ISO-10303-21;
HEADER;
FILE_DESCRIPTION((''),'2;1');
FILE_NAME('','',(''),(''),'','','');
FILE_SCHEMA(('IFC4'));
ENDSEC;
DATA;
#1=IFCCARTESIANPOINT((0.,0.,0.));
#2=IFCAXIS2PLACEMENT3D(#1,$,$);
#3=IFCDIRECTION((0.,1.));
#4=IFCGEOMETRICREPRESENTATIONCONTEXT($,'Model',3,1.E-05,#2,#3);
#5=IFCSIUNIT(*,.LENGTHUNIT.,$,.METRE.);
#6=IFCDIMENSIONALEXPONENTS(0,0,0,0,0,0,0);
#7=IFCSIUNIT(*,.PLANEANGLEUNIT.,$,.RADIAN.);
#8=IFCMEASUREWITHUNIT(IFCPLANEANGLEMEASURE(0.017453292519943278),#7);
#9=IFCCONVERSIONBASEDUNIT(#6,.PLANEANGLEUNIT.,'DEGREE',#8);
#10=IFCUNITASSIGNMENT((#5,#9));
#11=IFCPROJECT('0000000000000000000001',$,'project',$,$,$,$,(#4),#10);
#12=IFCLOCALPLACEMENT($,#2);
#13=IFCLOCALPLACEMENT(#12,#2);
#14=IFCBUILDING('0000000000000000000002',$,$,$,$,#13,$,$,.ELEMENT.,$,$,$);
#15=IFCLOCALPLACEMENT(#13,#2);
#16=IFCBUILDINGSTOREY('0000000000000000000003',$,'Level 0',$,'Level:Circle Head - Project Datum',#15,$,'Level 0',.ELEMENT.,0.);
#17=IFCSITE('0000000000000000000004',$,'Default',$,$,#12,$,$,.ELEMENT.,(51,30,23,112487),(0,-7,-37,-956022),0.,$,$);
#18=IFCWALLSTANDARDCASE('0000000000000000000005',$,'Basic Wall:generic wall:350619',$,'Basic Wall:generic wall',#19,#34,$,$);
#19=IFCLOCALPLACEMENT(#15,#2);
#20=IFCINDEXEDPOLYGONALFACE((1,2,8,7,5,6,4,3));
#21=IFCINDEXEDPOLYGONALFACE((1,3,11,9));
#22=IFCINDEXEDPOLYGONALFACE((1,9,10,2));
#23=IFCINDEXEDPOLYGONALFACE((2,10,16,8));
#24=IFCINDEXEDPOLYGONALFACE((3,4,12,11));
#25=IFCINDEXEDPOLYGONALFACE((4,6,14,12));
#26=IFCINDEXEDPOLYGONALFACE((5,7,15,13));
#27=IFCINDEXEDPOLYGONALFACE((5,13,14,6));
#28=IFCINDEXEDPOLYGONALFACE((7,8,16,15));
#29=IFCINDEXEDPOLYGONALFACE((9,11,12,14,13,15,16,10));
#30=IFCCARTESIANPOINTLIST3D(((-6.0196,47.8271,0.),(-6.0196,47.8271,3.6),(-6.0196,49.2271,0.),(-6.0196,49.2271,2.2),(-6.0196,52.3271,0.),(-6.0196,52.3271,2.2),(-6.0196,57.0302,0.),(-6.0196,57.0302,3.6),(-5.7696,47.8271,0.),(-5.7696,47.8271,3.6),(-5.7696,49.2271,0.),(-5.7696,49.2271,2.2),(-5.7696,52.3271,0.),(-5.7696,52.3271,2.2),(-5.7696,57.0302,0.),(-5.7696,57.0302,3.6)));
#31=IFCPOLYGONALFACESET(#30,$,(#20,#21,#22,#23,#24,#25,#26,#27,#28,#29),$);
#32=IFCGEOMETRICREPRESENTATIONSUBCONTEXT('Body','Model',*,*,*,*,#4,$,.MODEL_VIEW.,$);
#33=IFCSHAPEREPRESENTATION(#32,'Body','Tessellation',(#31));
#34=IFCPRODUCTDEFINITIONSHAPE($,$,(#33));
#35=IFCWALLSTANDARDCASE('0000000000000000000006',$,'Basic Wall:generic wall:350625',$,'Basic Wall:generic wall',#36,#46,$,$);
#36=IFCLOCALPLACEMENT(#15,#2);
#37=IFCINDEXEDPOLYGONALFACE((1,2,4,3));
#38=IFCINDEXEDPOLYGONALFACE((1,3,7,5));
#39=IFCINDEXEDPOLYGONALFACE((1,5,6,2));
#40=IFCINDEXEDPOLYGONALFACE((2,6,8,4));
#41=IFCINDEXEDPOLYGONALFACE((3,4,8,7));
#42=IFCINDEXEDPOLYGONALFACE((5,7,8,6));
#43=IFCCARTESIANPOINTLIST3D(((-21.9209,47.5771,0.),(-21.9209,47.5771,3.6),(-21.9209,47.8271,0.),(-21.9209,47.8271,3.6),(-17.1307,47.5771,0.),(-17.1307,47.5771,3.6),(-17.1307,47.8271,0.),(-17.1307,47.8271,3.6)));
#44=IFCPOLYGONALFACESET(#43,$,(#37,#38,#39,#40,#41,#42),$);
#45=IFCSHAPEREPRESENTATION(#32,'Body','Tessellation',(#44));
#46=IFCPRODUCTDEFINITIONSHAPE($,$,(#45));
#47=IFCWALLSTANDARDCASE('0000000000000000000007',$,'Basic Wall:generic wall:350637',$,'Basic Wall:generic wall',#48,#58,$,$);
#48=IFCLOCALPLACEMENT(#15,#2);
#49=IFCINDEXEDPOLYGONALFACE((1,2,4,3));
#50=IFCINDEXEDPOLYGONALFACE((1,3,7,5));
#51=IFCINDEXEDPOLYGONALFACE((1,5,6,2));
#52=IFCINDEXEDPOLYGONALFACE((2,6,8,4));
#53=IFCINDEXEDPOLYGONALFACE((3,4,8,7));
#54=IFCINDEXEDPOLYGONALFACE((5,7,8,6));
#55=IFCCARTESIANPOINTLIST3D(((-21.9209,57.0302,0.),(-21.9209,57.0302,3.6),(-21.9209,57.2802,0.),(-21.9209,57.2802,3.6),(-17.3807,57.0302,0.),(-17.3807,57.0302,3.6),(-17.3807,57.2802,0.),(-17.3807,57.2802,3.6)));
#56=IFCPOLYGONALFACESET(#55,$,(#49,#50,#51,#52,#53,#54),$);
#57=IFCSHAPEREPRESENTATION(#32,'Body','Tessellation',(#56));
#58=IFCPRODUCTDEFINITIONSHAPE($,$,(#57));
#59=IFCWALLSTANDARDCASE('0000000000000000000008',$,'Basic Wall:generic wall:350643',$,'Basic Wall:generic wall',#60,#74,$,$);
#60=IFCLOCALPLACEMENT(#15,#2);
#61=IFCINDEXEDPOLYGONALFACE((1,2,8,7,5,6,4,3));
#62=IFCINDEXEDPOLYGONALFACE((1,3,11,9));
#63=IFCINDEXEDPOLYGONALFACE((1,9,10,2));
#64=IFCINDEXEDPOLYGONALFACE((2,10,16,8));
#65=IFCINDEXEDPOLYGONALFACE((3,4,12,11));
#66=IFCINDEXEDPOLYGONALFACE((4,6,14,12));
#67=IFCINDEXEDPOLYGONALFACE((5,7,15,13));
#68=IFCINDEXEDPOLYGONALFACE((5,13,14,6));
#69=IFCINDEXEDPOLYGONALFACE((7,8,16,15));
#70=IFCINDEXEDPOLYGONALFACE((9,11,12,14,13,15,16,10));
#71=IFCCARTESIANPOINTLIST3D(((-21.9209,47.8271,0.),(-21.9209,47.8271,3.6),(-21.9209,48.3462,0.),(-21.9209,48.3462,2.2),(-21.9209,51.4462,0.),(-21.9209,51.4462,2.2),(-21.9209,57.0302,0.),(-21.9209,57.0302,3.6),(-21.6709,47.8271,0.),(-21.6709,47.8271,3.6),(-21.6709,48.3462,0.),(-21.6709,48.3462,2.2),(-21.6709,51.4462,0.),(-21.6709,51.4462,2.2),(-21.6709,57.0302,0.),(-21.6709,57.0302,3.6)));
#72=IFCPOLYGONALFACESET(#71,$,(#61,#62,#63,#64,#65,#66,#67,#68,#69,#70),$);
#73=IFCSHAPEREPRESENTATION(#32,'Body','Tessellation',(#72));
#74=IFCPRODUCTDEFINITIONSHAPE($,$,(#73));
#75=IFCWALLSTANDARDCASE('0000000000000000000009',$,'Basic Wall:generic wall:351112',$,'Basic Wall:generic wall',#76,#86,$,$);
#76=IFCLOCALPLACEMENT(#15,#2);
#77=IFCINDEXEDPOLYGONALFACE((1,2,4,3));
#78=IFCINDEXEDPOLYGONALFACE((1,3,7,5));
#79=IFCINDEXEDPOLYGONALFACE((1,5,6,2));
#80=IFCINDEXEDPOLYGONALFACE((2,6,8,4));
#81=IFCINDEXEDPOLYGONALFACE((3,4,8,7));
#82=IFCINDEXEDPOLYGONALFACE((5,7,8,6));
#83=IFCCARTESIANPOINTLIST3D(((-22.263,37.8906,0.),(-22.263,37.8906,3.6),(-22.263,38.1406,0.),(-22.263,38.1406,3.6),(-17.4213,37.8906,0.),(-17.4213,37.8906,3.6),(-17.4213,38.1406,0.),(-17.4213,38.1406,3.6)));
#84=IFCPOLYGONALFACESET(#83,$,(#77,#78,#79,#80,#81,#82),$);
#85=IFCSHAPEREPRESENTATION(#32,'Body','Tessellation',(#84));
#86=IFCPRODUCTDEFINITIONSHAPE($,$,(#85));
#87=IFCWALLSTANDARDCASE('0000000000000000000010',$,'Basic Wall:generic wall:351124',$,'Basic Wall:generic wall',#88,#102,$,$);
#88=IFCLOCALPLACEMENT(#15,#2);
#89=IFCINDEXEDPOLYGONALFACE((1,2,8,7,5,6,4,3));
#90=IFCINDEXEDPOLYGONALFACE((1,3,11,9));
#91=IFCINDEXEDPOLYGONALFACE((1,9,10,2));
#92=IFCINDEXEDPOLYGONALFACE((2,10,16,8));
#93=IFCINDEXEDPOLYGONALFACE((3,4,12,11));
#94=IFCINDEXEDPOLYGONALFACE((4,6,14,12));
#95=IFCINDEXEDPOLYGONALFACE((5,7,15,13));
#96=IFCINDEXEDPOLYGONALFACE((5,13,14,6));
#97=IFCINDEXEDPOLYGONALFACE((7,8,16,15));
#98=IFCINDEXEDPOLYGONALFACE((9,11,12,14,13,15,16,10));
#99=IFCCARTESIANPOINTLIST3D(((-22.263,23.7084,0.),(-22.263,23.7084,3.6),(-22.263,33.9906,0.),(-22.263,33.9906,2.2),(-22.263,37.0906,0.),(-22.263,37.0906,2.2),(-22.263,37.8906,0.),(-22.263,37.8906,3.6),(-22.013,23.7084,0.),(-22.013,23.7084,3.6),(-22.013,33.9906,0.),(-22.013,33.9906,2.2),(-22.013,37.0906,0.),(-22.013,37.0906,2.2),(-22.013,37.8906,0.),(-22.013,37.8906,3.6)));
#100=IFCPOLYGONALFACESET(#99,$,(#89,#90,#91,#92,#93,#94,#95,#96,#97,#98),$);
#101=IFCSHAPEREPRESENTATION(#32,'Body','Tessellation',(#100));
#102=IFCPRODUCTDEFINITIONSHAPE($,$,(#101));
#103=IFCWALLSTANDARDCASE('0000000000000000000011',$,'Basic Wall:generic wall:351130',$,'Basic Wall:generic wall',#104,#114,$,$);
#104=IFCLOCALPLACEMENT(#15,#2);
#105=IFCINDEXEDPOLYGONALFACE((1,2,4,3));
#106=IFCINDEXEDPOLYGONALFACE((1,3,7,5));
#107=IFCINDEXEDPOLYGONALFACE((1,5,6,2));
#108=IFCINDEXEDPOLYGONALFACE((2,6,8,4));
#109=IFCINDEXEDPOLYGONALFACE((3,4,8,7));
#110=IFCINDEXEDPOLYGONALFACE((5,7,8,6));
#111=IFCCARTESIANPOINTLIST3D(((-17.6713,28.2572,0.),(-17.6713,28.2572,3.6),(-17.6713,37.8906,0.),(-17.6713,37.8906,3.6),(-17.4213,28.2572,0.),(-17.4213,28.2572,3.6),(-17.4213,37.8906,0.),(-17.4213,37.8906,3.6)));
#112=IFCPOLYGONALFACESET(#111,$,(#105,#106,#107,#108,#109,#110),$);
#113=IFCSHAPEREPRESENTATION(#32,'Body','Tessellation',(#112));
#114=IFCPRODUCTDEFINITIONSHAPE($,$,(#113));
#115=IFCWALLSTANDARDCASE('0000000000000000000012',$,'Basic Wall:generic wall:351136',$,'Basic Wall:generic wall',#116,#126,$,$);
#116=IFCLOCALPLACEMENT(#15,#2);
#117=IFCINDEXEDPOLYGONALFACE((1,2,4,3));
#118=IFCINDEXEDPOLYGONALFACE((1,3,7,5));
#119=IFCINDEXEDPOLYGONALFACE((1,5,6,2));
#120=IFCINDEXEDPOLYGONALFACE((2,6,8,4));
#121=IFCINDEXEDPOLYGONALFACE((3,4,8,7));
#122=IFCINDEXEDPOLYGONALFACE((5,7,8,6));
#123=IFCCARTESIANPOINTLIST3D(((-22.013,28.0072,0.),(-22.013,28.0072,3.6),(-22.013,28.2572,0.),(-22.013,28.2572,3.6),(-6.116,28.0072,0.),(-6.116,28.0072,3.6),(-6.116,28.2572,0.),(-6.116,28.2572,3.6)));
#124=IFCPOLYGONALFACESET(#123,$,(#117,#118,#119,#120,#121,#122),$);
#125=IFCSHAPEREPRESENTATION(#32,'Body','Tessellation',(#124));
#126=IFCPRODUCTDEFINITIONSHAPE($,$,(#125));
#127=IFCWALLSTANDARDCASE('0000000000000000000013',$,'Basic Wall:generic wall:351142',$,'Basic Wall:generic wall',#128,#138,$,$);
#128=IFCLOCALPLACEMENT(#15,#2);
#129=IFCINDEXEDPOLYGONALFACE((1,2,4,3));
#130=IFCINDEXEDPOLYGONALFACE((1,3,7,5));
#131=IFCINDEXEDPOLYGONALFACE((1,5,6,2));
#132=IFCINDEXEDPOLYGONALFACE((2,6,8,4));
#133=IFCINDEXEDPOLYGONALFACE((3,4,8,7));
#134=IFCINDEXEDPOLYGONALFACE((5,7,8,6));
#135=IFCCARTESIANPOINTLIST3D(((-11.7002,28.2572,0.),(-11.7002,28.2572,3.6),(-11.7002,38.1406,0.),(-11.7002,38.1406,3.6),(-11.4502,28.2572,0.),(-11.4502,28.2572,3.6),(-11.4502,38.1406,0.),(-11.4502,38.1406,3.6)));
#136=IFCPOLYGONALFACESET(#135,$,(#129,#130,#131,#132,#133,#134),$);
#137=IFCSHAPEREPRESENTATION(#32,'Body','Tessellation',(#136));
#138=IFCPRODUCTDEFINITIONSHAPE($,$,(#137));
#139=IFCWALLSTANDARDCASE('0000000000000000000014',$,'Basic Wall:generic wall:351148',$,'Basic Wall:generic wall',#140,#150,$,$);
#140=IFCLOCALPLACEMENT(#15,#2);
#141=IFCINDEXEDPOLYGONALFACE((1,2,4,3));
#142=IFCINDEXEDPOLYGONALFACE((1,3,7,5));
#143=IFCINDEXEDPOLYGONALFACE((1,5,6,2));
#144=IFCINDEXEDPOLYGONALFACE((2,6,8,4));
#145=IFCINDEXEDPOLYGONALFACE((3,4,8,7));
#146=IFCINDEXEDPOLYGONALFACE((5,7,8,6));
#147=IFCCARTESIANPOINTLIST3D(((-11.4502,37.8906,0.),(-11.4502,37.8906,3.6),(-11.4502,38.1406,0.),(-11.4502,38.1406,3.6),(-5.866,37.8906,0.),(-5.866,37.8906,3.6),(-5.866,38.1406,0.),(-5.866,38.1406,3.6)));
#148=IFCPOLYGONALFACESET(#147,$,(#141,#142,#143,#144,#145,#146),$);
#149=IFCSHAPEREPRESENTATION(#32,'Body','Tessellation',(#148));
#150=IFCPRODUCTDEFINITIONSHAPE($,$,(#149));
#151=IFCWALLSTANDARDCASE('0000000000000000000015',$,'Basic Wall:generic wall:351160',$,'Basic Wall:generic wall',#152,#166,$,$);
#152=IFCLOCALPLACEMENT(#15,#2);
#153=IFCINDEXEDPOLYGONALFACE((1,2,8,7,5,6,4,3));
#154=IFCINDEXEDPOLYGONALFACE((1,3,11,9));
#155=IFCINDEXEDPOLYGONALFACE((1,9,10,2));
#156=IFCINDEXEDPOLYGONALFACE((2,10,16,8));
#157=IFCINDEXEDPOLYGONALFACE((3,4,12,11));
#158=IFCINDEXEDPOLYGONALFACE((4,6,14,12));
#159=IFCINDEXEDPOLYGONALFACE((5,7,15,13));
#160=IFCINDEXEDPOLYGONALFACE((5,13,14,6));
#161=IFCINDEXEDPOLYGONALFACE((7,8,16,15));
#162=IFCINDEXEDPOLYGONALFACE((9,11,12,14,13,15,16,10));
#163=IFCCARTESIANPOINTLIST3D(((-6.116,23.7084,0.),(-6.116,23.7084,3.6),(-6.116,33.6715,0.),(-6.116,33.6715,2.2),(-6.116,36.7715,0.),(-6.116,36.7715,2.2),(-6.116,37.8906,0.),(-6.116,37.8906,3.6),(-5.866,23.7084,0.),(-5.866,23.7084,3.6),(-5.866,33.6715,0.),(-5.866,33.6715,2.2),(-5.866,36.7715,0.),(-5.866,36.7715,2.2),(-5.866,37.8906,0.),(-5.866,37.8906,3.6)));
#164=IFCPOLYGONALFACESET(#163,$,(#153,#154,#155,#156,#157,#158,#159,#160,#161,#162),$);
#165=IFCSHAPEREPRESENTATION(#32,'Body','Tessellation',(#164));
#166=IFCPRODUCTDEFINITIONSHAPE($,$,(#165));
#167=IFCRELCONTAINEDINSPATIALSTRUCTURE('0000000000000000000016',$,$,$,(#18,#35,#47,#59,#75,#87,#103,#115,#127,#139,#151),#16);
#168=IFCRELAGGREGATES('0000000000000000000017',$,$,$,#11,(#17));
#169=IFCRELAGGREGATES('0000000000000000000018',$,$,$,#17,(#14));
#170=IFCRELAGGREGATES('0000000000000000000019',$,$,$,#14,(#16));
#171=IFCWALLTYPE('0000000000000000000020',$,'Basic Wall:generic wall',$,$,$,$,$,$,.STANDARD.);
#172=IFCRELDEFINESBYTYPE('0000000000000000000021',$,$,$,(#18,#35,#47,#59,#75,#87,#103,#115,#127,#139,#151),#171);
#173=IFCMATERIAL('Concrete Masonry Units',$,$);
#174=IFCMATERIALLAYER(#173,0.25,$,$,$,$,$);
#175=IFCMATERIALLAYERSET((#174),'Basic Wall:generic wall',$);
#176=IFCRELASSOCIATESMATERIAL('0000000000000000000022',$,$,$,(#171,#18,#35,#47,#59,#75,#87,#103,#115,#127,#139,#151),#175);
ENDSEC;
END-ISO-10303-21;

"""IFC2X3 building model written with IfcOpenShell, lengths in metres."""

from ifc_helpers import new_model, entity, si_unit, converted_unit, direction, frame, frame_2d, origin, place, context, subcontext, project, spatial, rectangle, extrude, material, layer, layer_set, layer_usage, type_object, element, save


model = new_model("IFC2X3")

# Units and contexts
model_context = context("Model", 3, precision=1e-05, world=origin(), true_north=direction((0.0, 1.0)))
body_context = subcontext(model_context, "Body", "Model", "MODEL_VIEW")
ifc_project = project(units=[si_unit("LENGTHUNIT", "METRE"), converted_unit("PLANEANGLEUNIT", "DEGREE", entity("IfcPlaneAngleMeasure", 0.017453292519943278), si_unit("PLANEANGLEUNIT", "RADIAN"), dimensions=[0, 0, 0, 0, 0, 0, 0])], contexts=[model_context])

# Site, building, storey
site_placement = place(None, origin())
site = spatial("IfcSite", under=ifc_project, at=site_placement, Name="Default", CompositionType="ELEMENT", RefLatitude=(51, 30, 23, 112487), RefLongitude=(0, -7, -37, -956022), RefElevation=0.0)
building_placement = place(site_placement, origin())
building = spatial("IfcBuilding", under=site, at=building_placement, CompositionType="ELEMENT")
storey_placement = place(building_placement, origin())
storey = spatial("IfcBuildingStorey", under=building, at=storey_placement, Name="Level 0", ObjectType="Level:Circle Head - Project Datum", LongName="Level 0", CompositionType="ELEMENT", Elevation=0.0)

# Shared definitions
ifc_material = material(Name="Concrete Masonry Units")
ifc_layer = layer(ifc_material, 0.25)
ifc_layer_set = layer_set([ifc_layer], Name="Basic Wall:generic wall")
wall_type = type_object("IfcWallType", Name="Basic Wall:generic wall", PredefinedType="STANDARD", material=ifc_layer_set)

# Wall, opening
ifc_layer_usage_1 = layer_usage(ifc_layer_set, "AXIS2", "NEGATIVE", 0.125)
wall_1_placement = place(storey_placement, frame((-5.8946, 57.0302, 0.0), z_axis=(0.0, 0.0, 1.0), x_axis=(0.0, -1.0, 0.0)))
wall_1 = element("IfcWallStandardCase", 1, at=wall_1_placement, inside=storey, type_object=wall_type, material=ifc_layer_usage_1, Name="Basic Wall:generic wall:350619", ObjectType="Basic Wall:generic wall", context=body_context, shape_type="SweptSolid", body=[
    extrude(rectangle(XDim=9.2031, YDim=0.25, at=frame_2d((4.6015, 0.0), x_axis=(1.0, 0.0))), origin(), (0.0, 0.0, 1.0), 3.6),
])
opening_1_placement = place(wall_1_placement, frame((7.8031, 0.125, 0.0)))
element("IfcOpeningElement", 2, at=opening_1_placement, cuts=wall_1, ObjectType="Opening", context=body_context, shape_type="SweptSolid", body=[
    extrude(rectangle(XDim=2.2, YDim=3.1, at=frame_2d((1.1, 1.55), x_axis=(1.0, 0.0))), frame((0.0, 0.0, 0.0), z_axis=(0.0, -1.0, 0.0), x_axis=(0.0, 0.0, 1.0)), (0.0, 0.0, 1.0), 0.25),
])

# Walls
ifc_layer_usage_2 = layer_usage(ifc_layer_set, "AXIS2", "NEGATIVE", 0.125)
wall_2_placement = place(storey_placement, frame((-17.1307, 47.7021, 0.0), z_axis=(0.0, 0.0, 1.0), x_axis=(-1.0, 0.0, 0.0)))
element("IfcWallStandardCase", 3, at=wall_2_placement, inside=storey, type_object=wall_type, material=ifc_layer_usage_2, Name="Basic Wall:generic wall:350625", ObjectType="Basic Wall:generic wall", context=body_context, shape_type="SweptSolid", body=[
    extrude(rectangle(XDim=4.7901, YDim=0.25, at=frame_2d((2.3951, 0.0), x_axis=(-1.0, 0.0))), origin(), (0.0, 0.0, 1.0), 3.6),
])
ifc_layer_usage_3 = layer_usage(ifc_layer_set, "AXIS2", "NEGATIVE", 0.125)
wall_3_placement = place(storey_placement, frame((-21.9209, 57.1552, 0.0)))
element("IfcWallStandardCase", 4, at=wall_3_placement, inside=storey, type_object=wall_type, material=ifc_layer_usage_3, Name="Basic Wall:generic wall:350637", ObjectType="Basic Wall:generic wall", context=body_context, shape_type="SweptSolid", body=[
    extrude(rectangle(XDim=4.5401, YDim=0.25, at=frame_2d((2.2701, 0.0), x_axis=(-1.0, 0.0))), origin(), (0.0, 0.0, 1.0), 3.6),
])

# Wall, opening
ifc_layer_usage_4 = layer_usage(ifc_layer_set, "AXIS2", "NEGATIVE", 0.125)
wall_4_placement = place(storey_placement, frame((-21.7959, 47.8271, 0.0), z_axis=(0.0, 0.0, 1.0), x_axis=(0.0, 1.0, 0.0)))
wall_4 = element("IfcWallStandardCase", 5, at=wall_4_placement, inside=storey, type_object=wall_type, material=ifc_layer_usage_4, Name="Basic Wall:generic wall:350643", ObjectType="Basic Wall:generic wall", context=body_context, shape_type="SweptSolid", body=[
    extrude(rectangle(XDim=9.2031, YDim=0.25, at=frame_2d((4.6015, 0.0), x_axis=(-1.0, 0.0))), origin(), (0.0, 0.0, 1.0), 3.6),
])
opening_2_placement = place(wall_4_placement, frame((3.619, 0.125, 0.0)))
element("IfcOpeningElement", 6, at=opening_2_placement, cuts=wall_4, ObjectType="Opening", context=body_context, shape_type="SweptSolid", body=[
    extrude(rectangle(XDim=2.2, YDim=3.1, at=frame_2d((1.1, 1.55), x_axis=(1.0, 0.0))), frame((0.0, 0.0, 0.0), z_axis=(0.0, -1.0, 0.0), x_axis=(0.0, 0.0, 1.0)), (0.0, 0.0, 1.0), 0.25),
])

# Wall
ifc_layer_usage_5 = layer_usage(ifc_layer_set, "AXIS2", "NEGATIVE", 0.125)
wall_5_placement = place(storey_placement, frame((-22.263, 38.0156, 0.0)))
element("IfcWallStandardCase", 7, at=wall_5_placement, inside=storey, type_object=wall_type, material=ifc_layer_usage_5, Name="Basic Wall:generic wall:351112", ObjectType="Basic Wall:generic wall", context=body_context, shape_type="SweptSolid", body=[
    extrude(rectangle(XDim=4.8417, YDim=0.25, at=frame_2d((2.4208, 0.0), x_axis=(-1.0, 0.0))), origin(), (0.0, 0.0, 1.0), 3.6),
])

# Wall, opening
ifc_layer_usage_6 = layer_usage(ifc_layer_set, "AXIS2", "NEGATIVE", 0.125)
wall_6_placement = place(storey_placement, frame((-22.138, 23.7084, 0.0), z_axis=(0.0, 0.0, 1.0), x_axis=(0.0, 1.0, 0.0)))
wall_6 = element("IfcWallStandardCase", 8, at=wall_6_placement, inside=storey, type_object=wall_type, material=ifc_layer_usage_6, Name="Basic Wall:generic wall:351124", ObjectType="Basic Wall:generic wall", context=body_context, shape_type="SweptSolid", body=[
    extrude(rectangle(XDim=14.1822, YDim=0.25, at=frame_2d((7.0911, 0.0), x_axis=(-1.0, 0.0))), origin(), (0.0, 0.0, 1.0), 3.6),
])
opening_3_placement = place(wall_6_placement, frame((13.3822, 0.125, 0.0)))
element("IfcOpeningElement", 9, at=opening_3_placement, cuts=wall_6, ObjectType="Opening", context=body_context, shape_type="SweptSolid", body=[
    extrude(rectangle(XDim=2.2, YDim=3.1, at=frame_2d((1.1, 1.55), x_axis=(1.0, 0.0))), frame((0.0, 0.0, 0.0), z_axis=(0.0, -1.0, 0.0), x_axis=(0.0, 0.0, 1.0)), (0.0, 0.0, 1.0), 0.25),
])

# Walls
ifc_layer_usage_7 = layer_usage(ifc_layer_set, "AXIS2", "NEGATIVE", 0.125)
wall_7_placement = place(storey_placement, frame((-17.5463, 37.8906, 0.0), z_axis=(0.0, 0.0, 1.0), x_axis=(0.0, -1.0, 0.0)))
element("IfcWallStandardCase", 10, at=wall_7_placement, inside=storey, type_object=wall_type, material=ifc_layer_usage_7, Name="Basic Wall:generic wall:351130", ObjectType="Basic Wall:generic wall", context=body_context, shape_type="SweptSolid", body=[
    extrude(rectangle(XDim=9.6334, YDim=0.25, at=frame_2d((4.8167, 0.0), x_axis=(-1.0, 0.0))), origin(), (0.0, 0.0, 1.0), 3.6),
])
ifc_layer_usage_8 = layer_usage(ifc_layer_set, "AXIS2", "NEGATIVE", 0.125)
wall_8_placement = place(storey_placement, frame((-6.116, 28.1322, 0.0), z_axis=(0.0, 0.0, 1.0), x_axis=(-1.0, 0.0, 0.0)))
element("IfcWallStandardCase", 11, at=wall_8_placement, inside=storey, type_object=wall_type, material=ifc_layer_usage_8, Name="Basic Wall:generic wall:351136", ObjectType="Basic Wall:generic wall", context=body_context, shape_type="SweptSolid", body=[
    extrude(rectangle(XDim=15.8969, YDim=0.25, at=frame_2d((7.9485, 0.0), x_axis=(-1.0, 0.0))), origin(), (0.0, 0.0, 1.0), 3.6),
])
ifc_layer_usage_9 = layer_usage(ifc_layer_set, "AXIS2", "NEGATIVE", 0.125)
wall_9_placement = place(storey_placement, frame((-11.5752, 28.2572, 0.0), z_axis=(0.0, 0.0, 1.0), x_axis=(0.0, 1.0, 0.0)))
element("IfcWallStandardCase", 12, at=wall_9_placement, inside=storey, type_object=wall_type, material=ifc_layer_usage_9, Name="Basic Wall:generic wall:351142", ObjectType="Basic Wall:generic wall", context=body_context, shape_type="SweptSolid", body=[
    extrude(rectangle(XDim=9.8834, YDim=0.25, at=frame_2d((4.9417, 0.0), x_axis=(-1.0, 0.0))), origin(), (0.0, 0.0, 1.0), 3.6),
])
ifc_layer_usage_10 = layer_usage(ifc_layer_set, "AXIS2", "NEGATIVE", 0.125)
wall_10_placement = place(storey_placement, frame((-11.4502, 38.0156, 0.0)))
element("IfcWallStandardCase", 13, at=wall_10_placement, inside=storey, type_object=wall_type, material=ifc_layer_usage_10, Name="Basic Wall:generic wall:351148", ObjectType="Basic Wall:generic wall", context=body_context, shape_type="SweptSolid", body=[
    extrude(rectangle(XDim=5.5841, YDim=0.25, at=frame_2d((2.7921, 0.0), x_axis=(-1.0, 0.0))), origin(), (0.0, 0.0, 1.0), 3.6),
])

# Wall, opening
ifc_layer_usage_11 = layer_usage(ifc_layer_set, "AXIS2", "NEGATIVE", 0.125)
wall_11_placement = place(storey_placement, frame((-5.991, 37.8906, 0.0), z_axis=(0.0, 0.0, 1.0), x_axis=(0.0, -1.0, 0.0)))
wall_11 = element("IfcWallStandardCase", 14, at=wall_11_placement, inside=storey, type_object=wall_type, material=ifc_layer_usage_11, Name="Basic Wall:generic wall:351160", ObjectType="Basic Wall:generic wall", context=body_context, shape_type="SweptSolid", body=[
    extrude(rectangle(XDim=14.1822, YDim=0.25, at=frame_2d((7.0911, 0.0), x_axis=(1.0, 0.0))), origin(), (0.0, 0.0, 1.0), 3.6),
])
opening_4_placement = place(wall_11_placement, frame((4.219, 0.125, 0.0)))
element("IfcOpeningElement", 15, at=opening_4_placement, cuts=wall_11, ObjectType="Opening", context=body_context, shape_type="SweptSolid", body=[
    extrude(rectangle(XDim=2.2, YDim=3.1, at=frame_2d((1.1, 1.55), x_axis=(1.0, 0.0))), frame((0.0, 0.0, 0.0), z_axis=(0.0, -1.0, 0.0), x_axis=(0.0, 0.0, 1.0)), (0.0, 0.0, 1.0), 0.25),
])

save(model, "model.ifc")
